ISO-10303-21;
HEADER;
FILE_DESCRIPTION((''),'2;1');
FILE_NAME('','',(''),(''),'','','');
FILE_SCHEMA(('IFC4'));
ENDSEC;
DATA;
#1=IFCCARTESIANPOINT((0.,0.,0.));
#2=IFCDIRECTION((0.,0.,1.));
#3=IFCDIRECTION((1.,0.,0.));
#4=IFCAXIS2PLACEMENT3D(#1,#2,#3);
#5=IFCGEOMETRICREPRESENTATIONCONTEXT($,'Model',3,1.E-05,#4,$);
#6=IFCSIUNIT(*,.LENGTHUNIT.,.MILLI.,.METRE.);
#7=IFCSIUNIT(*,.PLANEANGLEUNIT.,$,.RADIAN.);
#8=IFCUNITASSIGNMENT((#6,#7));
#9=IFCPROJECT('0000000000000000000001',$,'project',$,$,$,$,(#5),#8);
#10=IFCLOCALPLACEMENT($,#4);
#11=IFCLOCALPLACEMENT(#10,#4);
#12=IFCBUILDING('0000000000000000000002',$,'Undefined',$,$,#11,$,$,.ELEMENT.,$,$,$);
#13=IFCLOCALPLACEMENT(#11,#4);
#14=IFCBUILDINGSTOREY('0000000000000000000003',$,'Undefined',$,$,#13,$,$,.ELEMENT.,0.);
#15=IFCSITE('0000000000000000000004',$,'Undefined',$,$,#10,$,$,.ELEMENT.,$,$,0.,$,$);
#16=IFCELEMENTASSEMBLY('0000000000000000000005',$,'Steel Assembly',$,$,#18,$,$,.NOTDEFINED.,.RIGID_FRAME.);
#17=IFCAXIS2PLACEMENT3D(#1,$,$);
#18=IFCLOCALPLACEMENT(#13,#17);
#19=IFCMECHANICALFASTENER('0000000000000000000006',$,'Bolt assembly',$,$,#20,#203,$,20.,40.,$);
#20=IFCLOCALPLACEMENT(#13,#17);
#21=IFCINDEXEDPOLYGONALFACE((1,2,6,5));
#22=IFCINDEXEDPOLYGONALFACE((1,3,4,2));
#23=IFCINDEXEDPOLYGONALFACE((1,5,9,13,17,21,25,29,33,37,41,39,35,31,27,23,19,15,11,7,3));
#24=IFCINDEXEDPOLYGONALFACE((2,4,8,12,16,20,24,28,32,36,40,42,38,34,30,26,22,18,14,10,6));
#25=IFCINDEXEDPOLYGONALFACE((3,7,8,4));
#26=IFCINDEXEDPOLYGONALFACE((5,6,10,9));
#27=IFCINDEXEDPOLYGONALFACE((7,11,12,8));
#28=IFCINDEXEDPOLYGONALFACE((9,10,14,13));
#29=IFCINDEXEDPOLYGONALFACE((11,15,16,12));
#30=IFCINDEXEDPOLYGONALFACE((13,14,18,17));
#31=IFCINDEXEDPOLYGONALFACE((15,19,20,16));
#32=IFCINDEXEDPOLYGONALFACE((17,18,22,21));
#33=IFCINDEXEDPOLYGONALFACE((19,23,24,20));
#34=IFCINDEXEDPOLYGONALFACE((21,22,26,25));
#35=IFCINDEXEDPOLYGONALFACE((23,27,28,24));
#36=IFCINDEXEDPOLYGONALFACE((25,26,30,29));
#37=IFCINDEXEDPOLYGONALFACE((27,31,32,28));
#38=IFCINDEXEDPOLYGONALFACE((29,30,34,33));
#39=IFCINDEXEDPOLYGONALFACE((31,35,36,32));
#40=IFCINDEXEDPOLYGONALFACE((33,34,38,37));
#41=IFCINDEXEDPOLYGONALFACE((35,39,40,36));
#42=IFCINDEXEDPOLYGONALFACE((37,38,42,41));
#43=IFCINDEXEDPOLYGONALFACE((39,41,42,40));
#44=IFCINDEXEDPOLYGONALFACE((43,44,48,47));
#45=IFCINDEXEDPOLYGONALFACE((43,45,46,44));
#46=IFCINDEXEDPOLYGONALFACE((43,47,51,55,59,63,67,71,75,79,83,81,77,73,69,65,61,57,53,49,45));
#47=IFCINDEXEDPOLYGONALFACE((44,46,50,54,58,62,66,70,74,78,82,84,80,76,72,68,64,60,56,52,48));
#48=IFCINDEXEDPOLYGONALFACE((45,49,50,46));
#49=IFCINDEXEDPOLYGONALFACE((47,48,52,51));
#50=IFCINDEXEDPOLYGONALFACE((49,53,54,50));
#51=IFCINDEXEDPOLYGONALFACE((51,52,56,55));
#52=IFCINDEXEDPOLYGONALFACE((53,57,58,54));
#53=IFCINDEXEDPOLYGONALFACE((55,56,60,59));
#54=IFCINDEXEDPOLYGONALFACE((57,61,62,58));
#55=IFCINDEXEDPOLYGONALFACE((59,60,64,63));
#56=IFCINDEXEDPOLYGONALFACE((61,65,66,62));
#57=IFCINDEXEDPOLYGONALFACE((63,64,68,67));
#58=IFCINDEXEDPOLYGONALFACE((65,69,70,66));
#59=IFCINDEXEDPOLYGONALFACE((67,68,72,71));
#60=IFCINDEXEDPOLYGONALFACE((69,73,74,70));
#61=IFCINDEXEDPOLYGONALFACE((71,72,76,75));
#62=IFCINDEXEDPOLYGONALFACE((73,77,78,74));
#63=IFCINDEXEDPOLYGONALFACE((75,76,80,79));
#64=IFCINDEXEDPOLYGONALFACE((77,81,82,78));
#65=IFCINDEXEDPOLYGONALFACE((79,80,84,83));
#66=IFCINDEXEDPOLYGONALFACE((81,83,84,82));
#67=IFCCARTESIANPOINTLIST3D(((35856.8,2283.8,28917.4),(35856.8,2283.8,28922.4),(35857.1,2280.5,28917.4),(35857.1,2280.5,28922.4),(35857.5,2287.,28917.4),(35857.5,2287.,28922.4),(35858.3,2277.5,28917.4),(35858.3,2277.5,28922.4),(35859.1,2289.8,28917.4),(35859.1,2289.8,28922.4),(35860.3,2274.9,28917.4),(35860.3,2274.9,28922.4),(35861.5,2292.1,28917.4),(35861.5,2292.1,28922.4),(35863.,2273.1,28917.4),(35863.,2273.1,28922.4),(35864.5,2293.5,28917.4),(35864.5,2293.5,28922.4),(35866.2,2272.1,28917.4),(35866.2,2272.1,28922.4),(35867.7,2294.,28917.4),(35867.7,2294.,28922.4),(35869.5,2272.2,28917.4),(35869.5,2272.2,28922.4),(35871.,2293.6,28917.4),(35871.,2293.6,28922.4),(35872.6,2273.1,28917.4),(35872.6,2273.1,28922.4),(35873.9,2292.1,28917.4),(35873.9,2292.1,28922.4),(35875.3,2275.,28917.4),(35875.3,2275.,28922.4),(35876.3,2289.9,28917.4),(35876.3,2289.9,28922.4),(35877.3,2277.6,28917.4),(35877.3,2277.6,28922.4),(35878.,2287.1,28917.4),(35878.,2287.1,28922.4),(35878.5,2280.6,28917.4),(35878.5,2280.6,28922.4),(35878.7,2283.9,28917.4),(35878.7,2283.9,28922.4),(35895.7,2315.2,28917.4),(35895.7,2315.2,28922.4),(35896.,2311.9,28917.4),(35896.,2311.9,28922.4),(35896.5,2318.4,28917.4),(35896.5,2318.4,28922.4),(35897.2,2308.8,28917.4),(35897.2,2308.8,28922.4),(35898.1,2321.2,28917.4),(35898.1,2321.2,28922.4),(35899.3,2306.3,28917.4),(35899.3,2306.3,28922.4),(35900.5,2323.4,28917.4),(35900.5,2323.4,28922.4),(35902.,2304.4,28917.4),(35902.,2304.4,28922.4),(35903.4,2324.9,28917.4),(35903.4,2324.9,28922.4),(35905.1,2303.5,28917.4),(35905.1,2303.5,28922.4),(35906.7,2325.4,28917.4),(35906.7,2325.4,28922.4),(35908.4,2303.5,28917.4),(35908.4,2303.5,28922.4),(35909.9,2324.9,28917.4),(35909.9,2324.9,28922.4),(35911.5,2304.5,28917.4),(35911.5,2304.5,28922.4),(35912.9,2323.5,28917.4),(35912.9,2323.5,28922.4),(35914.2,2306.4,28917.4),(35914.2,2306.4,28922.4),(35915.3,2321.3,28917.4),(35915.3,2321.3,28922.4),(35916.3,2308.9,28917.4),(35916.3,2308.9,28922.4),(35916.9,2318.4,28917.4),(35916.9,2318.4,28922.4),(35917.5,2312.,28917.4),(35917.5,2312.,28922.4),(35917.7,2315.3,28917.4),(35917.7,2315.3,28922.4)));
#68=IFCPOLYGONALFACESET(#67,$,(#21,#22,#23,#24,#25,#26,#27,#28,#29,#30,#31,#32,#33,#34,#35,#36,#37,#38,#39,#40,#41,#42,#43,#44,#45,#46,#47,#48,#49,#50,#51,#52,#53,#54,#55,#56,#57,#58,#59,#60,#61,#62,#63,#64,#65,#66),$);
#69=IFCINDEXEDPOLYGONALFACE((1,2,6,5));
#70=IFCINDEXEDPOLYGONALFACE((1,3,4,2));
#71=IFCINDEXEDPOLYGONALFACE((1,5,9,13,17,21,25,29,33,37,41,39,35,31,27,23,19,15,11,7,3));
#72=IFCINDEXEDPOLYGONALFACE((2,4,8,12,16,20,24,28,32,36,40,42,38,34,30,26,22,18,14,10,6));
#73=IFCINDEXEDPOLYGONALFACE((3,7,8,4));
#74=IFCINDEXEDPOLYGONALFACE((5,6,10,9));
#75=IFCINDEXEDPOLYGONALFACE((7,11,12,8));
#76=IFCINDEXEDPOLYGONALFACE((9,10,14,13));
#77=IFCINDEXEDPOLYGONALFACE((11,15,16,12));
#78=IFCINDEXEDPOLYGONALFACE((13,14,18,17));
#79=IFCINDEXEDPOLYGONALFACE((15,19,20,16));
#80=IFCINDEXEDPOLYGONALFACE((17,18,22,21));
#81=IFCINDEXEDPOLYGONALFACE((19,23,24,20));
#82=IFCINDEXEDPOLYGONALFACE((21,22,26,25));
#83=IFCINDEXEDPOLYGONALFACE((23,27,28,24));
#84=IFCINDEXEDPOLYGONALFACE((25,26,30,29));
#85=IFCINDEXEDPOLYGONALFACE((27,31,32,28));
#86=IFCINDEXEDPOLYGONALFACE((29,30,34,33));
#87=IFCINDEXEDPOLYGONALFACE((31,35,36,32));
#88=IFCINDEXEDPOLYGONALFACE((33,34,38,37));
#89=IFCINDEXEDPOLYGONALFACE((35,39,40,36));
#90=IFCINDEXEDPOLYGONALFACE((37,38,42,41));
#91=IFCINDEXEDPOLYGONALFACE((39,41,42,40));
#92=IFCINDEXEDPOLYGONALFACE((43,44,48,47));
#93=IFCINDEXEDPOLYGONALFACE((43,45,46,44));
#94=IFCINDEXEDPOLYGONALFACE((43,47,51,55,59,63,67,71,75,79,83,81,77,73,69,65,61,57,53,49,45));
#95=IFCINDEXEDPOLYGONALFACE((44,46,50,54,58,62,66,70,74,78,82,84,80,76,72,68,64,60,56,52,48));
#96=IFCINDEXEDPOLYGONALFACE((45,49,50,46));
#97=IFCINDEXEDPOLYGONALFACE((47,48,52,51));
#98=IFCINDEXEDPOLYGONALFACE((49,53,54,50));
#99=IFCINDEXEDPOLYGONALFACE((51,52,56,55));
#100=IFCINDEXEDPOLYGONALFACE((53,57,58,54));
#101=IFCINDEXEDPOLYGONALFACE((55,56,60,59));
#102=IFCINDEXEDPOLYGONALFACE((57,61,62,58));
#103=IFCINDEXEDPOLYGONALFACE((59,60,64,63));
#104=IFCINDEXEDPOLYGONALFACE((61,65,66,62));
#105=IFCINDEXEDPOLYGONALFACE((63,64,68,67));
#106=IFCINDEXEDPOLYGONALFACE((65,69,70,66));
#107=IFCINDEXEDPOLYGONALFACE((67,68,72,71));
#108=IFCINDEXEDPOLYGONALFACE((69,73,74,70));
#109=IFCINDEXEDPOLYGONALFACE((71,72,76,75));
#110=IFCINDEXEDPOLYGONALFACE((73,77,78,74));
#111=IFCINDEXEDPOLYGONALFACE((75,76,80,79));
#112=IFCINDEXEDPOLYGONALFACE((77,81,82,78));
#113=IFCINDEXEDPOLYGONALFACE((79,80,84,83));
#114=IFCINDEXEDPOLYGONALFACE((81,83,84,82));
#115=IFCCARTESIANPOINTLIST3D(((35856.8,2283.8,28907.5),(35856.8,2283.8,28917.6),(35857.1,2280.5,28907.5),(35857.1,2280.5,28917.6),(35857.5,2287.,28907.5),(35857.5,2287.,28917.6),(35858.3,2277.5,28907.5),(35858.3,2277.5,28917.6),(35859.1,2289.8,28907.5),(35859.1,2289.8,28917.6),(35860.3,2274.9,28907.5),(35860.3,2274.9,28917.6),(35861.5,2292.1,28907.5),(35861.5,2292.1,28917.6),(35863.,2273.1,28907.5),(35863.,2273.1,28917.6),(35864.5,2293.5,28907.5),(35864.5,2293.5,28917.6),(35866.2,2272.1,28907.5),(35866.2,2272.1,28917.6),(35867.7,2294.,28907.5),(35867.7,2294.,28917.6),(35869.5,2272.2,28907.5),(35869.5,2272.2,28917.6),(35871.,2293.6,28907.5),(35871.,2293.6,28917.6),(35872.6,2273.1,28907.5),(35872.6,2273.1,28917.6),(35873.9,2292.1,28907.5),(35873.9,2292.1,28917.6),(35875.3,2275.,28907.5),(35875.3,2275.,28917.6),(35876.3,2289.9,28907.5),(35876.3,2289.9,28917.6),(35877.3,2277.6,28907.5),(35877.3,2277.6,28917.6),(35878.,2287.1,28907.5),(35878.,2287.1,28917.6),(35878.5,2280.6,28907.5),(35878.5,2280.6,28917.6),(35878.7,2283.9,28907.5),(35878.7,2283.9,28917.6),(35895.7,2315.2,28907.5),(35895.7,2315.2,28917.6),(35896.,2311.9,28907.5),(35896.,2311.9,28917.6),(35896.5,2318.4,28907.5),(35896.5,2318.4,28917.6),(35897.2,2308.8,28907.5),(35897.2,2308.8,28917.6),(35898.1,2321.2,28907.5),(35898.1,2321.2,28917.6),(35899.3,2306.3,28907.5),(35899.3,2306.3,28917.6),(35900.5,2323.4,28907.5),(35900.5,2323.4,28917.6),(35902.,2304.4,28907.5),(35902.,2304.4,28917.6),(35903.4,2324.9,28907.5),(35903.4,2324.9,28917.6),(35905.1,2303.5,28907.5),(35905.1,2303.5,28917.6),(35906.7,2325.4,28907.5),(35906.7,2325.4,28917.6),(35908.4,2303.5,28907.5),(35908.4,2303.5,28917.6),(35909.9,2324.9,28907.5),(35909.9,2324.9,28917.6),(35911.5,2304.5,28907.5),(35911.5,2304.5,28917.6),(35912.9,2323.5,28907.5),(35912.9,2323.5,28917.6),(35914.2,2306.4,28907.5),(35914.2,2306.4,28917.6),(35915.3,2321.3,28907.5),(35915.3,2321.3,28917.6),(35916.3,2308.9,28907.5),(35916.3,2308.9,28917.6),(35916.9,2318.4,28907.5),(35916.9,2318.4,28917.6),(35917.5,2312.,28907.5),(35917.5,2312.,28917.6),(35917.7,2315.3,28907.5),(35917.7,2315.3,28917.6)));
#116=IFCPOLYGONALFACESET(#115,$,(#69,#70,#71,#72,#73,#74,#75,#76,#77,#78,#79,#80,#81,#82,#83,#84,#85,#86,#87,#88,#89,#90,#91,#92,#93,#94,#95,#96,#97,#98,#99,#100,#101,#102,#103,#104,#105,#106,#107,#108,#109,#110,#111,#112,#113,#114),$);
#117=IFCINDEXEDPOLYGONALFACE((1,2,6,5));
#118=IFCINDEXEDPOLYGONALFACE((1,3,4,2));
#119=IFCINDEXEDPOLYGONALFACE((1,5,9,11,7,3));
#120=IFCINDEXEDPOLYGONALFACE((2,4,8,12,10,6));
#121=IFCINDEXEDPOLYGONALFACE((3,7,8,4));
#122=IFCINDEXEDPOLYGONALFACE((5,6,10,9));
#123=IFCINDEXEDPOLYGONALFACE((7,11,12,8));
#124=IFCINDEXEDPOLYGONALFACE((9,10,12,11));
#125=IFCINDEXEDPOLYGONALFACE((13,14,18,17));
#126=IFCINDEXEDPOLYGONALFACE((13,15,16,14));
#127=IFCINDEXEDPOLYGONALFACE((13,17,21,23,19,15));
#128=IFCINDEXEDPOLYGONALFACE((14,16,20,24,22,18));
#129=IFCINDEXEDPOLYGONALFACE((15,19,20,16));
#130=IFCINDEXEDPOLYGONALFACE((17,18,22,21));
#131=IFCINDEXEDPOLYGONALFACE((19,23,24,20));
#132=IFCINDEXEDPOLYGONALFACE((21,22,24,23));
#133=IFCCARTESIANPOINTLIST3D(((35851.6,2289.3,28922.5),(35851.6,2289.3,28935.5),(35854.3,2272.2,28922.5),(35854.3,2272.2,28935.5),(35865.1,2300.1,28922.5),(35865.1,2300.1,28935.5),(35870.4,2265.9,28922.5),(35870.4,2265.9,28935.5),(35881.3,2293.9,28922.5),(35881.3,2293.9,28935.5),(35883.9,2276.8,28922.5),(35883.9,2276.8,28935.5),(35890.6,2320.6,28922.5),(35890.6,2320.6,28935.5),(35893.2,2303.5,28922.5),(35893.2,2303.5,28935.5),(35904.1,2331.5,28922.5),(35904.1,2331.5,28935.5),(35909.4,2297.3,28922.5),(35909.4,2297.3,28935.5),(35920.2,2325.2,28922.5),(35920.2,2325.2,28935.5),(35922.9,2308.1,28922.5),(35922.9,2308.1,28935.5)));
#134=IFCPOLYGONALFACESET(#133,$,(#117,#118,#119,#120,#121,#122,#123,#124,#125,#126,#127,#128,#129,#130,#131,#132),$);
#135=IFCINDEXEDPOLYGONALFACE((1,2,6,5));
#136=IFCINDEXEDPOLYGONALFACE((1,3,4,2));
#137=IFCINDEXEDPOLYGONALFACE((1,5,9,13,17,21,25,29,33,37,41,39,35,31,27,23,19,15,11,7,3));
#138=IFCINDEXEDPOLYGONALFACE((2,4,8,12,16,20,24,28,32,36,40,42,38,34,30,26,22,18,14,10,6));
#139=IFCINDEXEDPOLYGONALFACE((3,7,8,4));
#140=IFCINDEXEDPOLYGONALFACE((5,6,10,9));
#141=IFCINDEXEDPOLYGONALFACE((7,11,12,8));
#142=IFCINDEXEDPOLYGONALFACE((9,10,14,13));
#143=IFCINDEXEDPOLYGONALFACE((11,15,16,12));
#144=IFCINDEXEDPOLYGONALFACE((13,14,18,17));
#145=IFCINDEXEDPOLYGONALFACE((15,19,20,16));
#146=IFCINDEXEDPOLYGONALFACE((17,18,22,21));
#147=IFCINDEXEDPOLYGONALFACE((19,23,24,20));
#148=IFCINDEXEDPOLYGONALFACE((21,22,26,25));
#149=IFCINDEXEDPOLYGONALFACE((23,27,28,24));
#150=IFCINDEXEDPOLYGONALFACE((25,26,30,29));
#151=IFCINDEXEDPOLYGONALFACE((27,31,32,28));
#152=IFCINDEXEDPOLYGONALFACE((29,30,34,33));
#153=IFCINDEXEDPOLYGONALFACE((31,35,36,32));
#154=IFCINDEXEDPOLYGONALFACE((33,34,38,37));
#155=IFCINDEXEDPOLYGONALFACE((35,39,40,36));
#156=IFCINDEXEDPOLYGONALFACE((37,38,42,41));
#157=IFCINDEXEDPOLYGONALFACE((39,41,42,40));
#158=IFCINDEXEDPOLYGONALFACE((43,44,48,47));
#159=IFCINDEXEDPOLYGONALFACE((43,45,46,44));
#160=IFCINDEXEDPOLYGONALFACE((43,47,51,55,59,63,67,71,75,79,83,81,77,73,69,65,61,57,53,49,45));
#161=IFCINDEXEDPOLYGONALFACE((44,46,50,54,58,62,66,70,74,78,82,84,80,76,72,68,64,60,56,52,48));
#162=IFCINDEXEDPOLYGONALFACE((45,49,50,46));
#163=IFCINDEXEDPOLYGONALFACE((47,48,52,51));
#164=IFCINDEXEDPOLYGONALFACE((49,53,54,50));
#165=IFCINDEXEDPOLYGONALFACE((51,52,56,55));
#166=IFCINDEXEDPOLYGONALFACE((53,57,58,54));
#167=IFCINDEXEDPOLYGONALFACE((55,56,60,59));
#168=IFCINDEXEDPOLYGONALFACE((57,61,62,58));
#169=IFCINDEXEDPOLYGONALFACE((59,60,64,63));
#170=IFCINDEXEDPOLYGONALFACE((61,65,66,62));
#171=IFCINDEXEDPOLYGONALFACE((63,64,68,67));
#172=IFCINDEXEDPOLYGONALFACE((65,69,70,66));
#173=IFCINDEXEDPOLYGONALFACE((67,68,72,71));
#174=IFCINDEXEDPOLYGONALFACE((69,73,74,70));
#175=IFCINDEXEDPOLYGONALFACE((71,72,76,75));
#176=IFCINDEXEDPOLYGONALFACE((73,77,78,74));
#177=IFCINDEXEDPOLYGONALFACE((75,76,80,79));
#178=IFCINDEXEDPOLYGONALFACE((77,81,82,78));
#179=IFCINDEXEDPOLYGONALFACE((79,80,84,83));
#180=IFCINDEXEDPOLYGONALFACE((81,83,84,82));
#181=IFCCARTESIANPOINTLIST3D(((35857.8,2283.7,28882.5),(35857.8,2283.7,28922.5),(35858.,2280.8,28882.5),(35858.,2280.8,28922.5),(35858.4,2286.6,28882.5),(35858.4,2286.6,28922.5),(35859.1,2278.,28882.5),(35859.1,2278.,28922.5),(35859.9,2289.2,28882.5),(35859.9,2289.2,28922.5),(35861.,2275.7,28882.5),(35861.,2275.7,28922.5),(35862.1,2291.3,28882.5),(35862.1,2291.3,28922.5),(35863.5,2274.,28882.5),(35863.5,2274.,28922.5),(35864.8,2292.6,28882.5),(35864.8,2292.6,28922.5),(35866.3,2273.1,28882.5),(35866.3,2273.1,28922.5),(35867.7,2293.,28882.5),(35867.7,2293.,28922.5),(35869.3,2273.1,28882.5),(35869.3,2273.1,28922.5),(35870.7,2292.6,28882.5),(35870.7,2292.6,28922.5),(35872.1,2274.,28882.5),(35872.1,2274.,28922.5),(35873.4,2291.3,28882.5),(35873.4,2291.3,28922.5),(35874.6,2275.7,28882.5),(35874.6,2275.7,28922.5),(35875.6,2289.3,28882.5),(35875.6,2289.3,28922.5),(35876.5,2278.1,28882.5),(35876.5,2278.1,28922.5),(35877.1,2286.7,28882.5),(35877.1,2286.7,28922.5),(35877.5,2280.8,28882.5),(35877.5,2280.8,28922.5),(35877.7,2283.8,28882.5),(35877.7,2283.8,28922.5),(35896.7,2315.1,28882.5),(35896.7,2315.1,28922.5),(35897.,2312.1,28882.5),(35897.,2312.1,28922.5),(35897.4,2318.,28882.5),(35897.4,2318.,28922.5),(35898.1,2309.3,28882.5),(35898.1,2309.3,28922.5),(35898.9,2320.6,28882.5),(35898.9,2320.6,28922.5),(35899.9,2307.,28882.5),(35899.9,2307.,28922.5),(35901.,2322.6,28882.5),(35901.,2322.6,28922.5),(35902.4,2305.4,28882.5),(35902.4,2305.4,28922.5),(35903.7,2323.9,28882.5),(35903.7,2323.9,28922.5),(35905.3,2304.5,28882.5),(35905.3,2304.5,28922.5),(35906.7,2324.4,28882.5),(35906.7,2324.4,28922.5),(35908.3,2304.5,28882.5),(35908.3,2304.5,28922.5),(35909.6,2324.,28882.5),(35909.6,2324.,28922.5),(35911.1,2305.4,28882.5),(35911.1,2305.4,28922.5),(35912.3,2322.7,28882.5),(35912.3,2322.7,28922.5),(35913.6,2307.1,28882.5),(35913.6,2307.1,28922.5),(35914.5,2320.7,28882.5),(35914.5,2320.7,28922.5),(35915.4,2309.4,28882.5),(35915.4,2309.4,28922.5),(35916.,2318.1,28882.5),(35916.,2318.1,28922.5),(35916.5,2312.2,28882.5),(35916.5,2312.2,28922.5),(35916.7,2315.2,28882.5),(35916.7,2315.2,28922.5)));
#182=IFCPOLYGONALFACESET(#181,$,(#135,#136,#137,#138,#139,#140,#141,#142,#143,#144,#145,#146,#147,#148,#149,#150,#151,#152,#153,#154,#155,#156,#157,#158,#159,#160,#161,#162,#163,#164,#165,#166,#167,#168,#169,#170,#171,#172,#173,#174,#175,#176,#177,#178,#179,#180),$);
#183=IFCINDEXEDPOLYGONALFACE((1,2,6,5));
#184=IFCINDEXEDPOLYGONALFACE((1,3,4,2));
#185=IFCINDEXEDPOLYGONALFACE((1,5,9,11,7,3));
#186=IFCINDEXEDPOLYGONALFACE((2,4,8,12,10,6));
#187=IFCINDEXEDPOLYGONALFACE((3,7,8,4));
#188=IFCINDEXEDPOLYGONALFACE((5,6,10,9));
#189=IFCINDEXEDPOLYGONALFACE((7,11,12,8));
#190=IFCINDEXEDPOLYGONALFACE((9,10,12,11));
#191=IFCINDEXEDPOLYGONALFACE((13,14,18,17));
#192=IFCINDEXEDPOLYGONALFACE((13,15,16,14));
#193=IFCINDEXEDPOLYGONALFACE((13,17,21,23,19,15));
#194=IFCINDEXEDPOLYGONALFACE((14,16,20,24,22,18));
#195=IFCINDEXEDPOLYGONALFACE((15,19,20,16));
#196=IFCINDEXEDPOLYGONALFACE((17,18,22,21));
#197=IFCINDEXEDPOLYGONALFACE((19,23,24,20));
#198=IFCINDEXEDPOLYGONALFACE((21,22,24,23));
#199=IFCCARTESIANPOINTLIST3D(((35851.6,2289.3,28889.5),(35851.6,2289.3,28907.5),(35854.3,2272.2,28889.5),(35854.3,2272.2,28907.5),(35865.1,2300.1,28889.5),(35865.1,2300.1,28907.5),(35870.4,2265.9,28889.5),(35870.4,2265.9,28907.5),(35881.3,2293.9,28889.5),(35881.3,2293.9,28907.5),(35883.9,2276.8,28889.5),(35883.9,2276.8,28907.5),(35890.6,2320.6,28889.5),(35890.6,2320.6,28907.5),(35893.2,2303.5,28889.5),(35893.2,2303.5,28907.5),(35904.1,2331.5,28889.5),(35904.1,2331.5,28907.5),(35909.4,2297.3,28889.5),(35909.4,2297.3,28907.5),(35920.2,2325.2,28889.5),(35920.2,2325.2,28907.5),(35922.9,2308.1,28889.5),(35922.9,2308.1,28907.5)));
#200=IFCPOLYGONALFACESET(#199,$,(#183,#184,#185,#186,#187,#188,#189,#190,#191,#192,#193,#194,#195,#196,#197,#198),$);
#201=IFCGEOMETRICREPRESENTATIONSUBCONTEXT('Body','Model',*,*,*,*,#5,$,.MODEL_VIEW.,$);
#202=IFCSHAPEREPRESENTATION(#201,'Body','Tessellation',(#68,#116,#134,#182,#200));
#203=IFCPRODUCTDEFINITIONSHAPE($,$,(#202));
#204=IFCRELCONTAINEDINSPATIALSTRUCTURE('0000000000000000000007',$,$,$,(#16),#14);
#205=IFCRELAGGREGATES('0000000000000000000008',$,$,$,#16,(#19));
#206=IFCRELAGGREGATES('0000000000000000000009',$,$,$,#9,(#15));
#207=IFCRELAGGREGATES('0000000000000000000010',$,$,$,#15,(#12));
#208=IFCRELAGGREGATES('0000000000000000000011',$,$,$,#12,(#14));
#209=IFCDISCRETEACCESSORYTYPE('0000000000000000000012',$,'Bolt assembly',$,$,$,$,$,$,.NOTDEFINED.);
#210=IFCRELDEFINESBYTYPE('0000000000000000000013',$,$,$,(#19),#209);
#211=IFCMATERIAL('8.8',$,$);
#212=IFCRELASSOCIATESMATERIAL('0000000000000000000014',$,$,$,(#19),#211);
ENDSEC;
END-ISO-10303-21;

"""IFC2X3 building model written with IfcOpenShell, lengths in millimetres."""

from ifc_helpers import new_model, si_unit, frame, origin_with_axes, origin_2d_with_axis, place, context, subcontext, project, spatial, polyline, circle, outline, extrude, source, transform, mapped, material, type_object, element, aggregate, save


model = new_model("IFC2X3")

# Units and contexts
model_context = context("Model", 3, precision=1e-05, world=origin_with_axes())
body_context = subcontext(model_context, "Body", "Model", "MODEL_VIEW")
ifc_project = project(units=[si_unit("LENGTHUNIT", "METRE", prefix="MILLI"), si_unit("PLANEANGLEUNIT", "RADIAN")], contexts=[model_context])

# Site, building, storey
site_placement = place(None, origin_with_axes())
site = spatial("IfcSite", under=ifc_project, at=site_placement, Name="Undefined", CompositionType="ELEMENT", RefElevation=0.0)
building_placement = place(site_placement, origin_with_axes())
building = spatial("IfcBuilding", under=site, at=building_placement, Name="Undefined", CompositionType="ELEMENT")
storey_placement = place(building_placement, origin_with_axes())
storey = spatial("IfcBuildingStorey", under=building, at=storey_placement, Name="Undefined", CompositionType="ELEMENT", Elevation=0.0)

# Shared definitions
discrete_accessory_type_1 = type_object("IfcDiscreteAccessoryType", Name="Bolt assembly")

# Shared definitions
ifc_material_1 = material(Name="8.8")

# Element assembly, mechanical fastener
shared_shape_1 = source(origin_with_axes(), body_context, "Body", "SweptSolid", [
    extrude(circle(Radius=11.0, at=origin_2d_with_axis()), frame((0.0, 0.1, 0.0), z_axis=(0.0, 1.0, 0.0), x_axis=(1.0, 0.0, 0.0)), (0.0, 0.0, 1.0), 5.0),
    extrude(circle(Radius=11.0, at=origin_2d_with_axis()), frame((0.0, 4.9, 0.0), z_axis=(0.0, 1.0, 0.0), x_axis=(1.0, 0.0, 0.0)), (0.0, 0.0, 1.0), 10.1),
    extrude(outline(polyline([(17.3, 0.0), (8.7, 15.0), (-8.7, 15.0), (-17.3, 0.0), (-8.7, -15.0), (8.7, -15.0), (17.3, 0.0)])), frame((0.0, -13.0, 0.0), z_axis=(0.0, 1.0, 0.0), x_axis=(1.0, 0.0, 0.0)), (0.0, 0.0, 1.0), 13.0),
    extrude(circle(Radius=10.0, at=origin_2d_with_axis()), frame((0.0, 0.0, 0.0), z_axis=(0.0, 1.0, 0.0), x_axis=(1.0, 0.0, 0.0)), (0.0, 0.0, 1.0), 40.0),
    extrude(outline(polyline([(17.3, 0.0), (8.7, 15.0), (-8.7, 15.0), (-17.3, 0.0), (-8.7, -15.0), (8.7, -15.0), (17.3, 0.0)])), frame((0.0, 15.0, 0.0), z_axis=(0.0, 1.0, 0.0), x_axis=(1.0, 0.0, 0.0)), (0.0, 0.0, 1.0), 18.0),
])
assembly_1_placement = place(storey_placement, origin_with_axes())
assembly_1 = element("IfcElementAssembly", 1, at=assembly_1_placement, inside=storey, Name="Steel Assembly", AssemblyPlace="NOTDEFINED", PredefinedType="RIGID_FRAME")
mechanical_fastener_1_placement = place(assembly_1_placement, frame((35867.8, 2283.0, 28922.5), z_axis=(-0.627081, 0.778954, 0.0), x_axis=(0.778954, 0.627081, 0.0)))
mechanical_fastener_1 = element("IfcMechanicalFastener", 2, at=mechanical_fastener_1_placement, type_object=discrete_accessory_type_1, material=ifc_material_1, Name="Bolt assembly", NominalDiameter=20.0, NominalLength=40.0, context=body_context, shape_type="MappedRepresentation", body=[
    mapped(shared_shape_1, transform((0.0, 0.0, 0.0))),
    mapped(shared_shape_1, transform((50.0, 0.0, 0.0))),
])

aggregate(assembly_1, [mechanical_fastener_1])

save(model, "model.ifc")
